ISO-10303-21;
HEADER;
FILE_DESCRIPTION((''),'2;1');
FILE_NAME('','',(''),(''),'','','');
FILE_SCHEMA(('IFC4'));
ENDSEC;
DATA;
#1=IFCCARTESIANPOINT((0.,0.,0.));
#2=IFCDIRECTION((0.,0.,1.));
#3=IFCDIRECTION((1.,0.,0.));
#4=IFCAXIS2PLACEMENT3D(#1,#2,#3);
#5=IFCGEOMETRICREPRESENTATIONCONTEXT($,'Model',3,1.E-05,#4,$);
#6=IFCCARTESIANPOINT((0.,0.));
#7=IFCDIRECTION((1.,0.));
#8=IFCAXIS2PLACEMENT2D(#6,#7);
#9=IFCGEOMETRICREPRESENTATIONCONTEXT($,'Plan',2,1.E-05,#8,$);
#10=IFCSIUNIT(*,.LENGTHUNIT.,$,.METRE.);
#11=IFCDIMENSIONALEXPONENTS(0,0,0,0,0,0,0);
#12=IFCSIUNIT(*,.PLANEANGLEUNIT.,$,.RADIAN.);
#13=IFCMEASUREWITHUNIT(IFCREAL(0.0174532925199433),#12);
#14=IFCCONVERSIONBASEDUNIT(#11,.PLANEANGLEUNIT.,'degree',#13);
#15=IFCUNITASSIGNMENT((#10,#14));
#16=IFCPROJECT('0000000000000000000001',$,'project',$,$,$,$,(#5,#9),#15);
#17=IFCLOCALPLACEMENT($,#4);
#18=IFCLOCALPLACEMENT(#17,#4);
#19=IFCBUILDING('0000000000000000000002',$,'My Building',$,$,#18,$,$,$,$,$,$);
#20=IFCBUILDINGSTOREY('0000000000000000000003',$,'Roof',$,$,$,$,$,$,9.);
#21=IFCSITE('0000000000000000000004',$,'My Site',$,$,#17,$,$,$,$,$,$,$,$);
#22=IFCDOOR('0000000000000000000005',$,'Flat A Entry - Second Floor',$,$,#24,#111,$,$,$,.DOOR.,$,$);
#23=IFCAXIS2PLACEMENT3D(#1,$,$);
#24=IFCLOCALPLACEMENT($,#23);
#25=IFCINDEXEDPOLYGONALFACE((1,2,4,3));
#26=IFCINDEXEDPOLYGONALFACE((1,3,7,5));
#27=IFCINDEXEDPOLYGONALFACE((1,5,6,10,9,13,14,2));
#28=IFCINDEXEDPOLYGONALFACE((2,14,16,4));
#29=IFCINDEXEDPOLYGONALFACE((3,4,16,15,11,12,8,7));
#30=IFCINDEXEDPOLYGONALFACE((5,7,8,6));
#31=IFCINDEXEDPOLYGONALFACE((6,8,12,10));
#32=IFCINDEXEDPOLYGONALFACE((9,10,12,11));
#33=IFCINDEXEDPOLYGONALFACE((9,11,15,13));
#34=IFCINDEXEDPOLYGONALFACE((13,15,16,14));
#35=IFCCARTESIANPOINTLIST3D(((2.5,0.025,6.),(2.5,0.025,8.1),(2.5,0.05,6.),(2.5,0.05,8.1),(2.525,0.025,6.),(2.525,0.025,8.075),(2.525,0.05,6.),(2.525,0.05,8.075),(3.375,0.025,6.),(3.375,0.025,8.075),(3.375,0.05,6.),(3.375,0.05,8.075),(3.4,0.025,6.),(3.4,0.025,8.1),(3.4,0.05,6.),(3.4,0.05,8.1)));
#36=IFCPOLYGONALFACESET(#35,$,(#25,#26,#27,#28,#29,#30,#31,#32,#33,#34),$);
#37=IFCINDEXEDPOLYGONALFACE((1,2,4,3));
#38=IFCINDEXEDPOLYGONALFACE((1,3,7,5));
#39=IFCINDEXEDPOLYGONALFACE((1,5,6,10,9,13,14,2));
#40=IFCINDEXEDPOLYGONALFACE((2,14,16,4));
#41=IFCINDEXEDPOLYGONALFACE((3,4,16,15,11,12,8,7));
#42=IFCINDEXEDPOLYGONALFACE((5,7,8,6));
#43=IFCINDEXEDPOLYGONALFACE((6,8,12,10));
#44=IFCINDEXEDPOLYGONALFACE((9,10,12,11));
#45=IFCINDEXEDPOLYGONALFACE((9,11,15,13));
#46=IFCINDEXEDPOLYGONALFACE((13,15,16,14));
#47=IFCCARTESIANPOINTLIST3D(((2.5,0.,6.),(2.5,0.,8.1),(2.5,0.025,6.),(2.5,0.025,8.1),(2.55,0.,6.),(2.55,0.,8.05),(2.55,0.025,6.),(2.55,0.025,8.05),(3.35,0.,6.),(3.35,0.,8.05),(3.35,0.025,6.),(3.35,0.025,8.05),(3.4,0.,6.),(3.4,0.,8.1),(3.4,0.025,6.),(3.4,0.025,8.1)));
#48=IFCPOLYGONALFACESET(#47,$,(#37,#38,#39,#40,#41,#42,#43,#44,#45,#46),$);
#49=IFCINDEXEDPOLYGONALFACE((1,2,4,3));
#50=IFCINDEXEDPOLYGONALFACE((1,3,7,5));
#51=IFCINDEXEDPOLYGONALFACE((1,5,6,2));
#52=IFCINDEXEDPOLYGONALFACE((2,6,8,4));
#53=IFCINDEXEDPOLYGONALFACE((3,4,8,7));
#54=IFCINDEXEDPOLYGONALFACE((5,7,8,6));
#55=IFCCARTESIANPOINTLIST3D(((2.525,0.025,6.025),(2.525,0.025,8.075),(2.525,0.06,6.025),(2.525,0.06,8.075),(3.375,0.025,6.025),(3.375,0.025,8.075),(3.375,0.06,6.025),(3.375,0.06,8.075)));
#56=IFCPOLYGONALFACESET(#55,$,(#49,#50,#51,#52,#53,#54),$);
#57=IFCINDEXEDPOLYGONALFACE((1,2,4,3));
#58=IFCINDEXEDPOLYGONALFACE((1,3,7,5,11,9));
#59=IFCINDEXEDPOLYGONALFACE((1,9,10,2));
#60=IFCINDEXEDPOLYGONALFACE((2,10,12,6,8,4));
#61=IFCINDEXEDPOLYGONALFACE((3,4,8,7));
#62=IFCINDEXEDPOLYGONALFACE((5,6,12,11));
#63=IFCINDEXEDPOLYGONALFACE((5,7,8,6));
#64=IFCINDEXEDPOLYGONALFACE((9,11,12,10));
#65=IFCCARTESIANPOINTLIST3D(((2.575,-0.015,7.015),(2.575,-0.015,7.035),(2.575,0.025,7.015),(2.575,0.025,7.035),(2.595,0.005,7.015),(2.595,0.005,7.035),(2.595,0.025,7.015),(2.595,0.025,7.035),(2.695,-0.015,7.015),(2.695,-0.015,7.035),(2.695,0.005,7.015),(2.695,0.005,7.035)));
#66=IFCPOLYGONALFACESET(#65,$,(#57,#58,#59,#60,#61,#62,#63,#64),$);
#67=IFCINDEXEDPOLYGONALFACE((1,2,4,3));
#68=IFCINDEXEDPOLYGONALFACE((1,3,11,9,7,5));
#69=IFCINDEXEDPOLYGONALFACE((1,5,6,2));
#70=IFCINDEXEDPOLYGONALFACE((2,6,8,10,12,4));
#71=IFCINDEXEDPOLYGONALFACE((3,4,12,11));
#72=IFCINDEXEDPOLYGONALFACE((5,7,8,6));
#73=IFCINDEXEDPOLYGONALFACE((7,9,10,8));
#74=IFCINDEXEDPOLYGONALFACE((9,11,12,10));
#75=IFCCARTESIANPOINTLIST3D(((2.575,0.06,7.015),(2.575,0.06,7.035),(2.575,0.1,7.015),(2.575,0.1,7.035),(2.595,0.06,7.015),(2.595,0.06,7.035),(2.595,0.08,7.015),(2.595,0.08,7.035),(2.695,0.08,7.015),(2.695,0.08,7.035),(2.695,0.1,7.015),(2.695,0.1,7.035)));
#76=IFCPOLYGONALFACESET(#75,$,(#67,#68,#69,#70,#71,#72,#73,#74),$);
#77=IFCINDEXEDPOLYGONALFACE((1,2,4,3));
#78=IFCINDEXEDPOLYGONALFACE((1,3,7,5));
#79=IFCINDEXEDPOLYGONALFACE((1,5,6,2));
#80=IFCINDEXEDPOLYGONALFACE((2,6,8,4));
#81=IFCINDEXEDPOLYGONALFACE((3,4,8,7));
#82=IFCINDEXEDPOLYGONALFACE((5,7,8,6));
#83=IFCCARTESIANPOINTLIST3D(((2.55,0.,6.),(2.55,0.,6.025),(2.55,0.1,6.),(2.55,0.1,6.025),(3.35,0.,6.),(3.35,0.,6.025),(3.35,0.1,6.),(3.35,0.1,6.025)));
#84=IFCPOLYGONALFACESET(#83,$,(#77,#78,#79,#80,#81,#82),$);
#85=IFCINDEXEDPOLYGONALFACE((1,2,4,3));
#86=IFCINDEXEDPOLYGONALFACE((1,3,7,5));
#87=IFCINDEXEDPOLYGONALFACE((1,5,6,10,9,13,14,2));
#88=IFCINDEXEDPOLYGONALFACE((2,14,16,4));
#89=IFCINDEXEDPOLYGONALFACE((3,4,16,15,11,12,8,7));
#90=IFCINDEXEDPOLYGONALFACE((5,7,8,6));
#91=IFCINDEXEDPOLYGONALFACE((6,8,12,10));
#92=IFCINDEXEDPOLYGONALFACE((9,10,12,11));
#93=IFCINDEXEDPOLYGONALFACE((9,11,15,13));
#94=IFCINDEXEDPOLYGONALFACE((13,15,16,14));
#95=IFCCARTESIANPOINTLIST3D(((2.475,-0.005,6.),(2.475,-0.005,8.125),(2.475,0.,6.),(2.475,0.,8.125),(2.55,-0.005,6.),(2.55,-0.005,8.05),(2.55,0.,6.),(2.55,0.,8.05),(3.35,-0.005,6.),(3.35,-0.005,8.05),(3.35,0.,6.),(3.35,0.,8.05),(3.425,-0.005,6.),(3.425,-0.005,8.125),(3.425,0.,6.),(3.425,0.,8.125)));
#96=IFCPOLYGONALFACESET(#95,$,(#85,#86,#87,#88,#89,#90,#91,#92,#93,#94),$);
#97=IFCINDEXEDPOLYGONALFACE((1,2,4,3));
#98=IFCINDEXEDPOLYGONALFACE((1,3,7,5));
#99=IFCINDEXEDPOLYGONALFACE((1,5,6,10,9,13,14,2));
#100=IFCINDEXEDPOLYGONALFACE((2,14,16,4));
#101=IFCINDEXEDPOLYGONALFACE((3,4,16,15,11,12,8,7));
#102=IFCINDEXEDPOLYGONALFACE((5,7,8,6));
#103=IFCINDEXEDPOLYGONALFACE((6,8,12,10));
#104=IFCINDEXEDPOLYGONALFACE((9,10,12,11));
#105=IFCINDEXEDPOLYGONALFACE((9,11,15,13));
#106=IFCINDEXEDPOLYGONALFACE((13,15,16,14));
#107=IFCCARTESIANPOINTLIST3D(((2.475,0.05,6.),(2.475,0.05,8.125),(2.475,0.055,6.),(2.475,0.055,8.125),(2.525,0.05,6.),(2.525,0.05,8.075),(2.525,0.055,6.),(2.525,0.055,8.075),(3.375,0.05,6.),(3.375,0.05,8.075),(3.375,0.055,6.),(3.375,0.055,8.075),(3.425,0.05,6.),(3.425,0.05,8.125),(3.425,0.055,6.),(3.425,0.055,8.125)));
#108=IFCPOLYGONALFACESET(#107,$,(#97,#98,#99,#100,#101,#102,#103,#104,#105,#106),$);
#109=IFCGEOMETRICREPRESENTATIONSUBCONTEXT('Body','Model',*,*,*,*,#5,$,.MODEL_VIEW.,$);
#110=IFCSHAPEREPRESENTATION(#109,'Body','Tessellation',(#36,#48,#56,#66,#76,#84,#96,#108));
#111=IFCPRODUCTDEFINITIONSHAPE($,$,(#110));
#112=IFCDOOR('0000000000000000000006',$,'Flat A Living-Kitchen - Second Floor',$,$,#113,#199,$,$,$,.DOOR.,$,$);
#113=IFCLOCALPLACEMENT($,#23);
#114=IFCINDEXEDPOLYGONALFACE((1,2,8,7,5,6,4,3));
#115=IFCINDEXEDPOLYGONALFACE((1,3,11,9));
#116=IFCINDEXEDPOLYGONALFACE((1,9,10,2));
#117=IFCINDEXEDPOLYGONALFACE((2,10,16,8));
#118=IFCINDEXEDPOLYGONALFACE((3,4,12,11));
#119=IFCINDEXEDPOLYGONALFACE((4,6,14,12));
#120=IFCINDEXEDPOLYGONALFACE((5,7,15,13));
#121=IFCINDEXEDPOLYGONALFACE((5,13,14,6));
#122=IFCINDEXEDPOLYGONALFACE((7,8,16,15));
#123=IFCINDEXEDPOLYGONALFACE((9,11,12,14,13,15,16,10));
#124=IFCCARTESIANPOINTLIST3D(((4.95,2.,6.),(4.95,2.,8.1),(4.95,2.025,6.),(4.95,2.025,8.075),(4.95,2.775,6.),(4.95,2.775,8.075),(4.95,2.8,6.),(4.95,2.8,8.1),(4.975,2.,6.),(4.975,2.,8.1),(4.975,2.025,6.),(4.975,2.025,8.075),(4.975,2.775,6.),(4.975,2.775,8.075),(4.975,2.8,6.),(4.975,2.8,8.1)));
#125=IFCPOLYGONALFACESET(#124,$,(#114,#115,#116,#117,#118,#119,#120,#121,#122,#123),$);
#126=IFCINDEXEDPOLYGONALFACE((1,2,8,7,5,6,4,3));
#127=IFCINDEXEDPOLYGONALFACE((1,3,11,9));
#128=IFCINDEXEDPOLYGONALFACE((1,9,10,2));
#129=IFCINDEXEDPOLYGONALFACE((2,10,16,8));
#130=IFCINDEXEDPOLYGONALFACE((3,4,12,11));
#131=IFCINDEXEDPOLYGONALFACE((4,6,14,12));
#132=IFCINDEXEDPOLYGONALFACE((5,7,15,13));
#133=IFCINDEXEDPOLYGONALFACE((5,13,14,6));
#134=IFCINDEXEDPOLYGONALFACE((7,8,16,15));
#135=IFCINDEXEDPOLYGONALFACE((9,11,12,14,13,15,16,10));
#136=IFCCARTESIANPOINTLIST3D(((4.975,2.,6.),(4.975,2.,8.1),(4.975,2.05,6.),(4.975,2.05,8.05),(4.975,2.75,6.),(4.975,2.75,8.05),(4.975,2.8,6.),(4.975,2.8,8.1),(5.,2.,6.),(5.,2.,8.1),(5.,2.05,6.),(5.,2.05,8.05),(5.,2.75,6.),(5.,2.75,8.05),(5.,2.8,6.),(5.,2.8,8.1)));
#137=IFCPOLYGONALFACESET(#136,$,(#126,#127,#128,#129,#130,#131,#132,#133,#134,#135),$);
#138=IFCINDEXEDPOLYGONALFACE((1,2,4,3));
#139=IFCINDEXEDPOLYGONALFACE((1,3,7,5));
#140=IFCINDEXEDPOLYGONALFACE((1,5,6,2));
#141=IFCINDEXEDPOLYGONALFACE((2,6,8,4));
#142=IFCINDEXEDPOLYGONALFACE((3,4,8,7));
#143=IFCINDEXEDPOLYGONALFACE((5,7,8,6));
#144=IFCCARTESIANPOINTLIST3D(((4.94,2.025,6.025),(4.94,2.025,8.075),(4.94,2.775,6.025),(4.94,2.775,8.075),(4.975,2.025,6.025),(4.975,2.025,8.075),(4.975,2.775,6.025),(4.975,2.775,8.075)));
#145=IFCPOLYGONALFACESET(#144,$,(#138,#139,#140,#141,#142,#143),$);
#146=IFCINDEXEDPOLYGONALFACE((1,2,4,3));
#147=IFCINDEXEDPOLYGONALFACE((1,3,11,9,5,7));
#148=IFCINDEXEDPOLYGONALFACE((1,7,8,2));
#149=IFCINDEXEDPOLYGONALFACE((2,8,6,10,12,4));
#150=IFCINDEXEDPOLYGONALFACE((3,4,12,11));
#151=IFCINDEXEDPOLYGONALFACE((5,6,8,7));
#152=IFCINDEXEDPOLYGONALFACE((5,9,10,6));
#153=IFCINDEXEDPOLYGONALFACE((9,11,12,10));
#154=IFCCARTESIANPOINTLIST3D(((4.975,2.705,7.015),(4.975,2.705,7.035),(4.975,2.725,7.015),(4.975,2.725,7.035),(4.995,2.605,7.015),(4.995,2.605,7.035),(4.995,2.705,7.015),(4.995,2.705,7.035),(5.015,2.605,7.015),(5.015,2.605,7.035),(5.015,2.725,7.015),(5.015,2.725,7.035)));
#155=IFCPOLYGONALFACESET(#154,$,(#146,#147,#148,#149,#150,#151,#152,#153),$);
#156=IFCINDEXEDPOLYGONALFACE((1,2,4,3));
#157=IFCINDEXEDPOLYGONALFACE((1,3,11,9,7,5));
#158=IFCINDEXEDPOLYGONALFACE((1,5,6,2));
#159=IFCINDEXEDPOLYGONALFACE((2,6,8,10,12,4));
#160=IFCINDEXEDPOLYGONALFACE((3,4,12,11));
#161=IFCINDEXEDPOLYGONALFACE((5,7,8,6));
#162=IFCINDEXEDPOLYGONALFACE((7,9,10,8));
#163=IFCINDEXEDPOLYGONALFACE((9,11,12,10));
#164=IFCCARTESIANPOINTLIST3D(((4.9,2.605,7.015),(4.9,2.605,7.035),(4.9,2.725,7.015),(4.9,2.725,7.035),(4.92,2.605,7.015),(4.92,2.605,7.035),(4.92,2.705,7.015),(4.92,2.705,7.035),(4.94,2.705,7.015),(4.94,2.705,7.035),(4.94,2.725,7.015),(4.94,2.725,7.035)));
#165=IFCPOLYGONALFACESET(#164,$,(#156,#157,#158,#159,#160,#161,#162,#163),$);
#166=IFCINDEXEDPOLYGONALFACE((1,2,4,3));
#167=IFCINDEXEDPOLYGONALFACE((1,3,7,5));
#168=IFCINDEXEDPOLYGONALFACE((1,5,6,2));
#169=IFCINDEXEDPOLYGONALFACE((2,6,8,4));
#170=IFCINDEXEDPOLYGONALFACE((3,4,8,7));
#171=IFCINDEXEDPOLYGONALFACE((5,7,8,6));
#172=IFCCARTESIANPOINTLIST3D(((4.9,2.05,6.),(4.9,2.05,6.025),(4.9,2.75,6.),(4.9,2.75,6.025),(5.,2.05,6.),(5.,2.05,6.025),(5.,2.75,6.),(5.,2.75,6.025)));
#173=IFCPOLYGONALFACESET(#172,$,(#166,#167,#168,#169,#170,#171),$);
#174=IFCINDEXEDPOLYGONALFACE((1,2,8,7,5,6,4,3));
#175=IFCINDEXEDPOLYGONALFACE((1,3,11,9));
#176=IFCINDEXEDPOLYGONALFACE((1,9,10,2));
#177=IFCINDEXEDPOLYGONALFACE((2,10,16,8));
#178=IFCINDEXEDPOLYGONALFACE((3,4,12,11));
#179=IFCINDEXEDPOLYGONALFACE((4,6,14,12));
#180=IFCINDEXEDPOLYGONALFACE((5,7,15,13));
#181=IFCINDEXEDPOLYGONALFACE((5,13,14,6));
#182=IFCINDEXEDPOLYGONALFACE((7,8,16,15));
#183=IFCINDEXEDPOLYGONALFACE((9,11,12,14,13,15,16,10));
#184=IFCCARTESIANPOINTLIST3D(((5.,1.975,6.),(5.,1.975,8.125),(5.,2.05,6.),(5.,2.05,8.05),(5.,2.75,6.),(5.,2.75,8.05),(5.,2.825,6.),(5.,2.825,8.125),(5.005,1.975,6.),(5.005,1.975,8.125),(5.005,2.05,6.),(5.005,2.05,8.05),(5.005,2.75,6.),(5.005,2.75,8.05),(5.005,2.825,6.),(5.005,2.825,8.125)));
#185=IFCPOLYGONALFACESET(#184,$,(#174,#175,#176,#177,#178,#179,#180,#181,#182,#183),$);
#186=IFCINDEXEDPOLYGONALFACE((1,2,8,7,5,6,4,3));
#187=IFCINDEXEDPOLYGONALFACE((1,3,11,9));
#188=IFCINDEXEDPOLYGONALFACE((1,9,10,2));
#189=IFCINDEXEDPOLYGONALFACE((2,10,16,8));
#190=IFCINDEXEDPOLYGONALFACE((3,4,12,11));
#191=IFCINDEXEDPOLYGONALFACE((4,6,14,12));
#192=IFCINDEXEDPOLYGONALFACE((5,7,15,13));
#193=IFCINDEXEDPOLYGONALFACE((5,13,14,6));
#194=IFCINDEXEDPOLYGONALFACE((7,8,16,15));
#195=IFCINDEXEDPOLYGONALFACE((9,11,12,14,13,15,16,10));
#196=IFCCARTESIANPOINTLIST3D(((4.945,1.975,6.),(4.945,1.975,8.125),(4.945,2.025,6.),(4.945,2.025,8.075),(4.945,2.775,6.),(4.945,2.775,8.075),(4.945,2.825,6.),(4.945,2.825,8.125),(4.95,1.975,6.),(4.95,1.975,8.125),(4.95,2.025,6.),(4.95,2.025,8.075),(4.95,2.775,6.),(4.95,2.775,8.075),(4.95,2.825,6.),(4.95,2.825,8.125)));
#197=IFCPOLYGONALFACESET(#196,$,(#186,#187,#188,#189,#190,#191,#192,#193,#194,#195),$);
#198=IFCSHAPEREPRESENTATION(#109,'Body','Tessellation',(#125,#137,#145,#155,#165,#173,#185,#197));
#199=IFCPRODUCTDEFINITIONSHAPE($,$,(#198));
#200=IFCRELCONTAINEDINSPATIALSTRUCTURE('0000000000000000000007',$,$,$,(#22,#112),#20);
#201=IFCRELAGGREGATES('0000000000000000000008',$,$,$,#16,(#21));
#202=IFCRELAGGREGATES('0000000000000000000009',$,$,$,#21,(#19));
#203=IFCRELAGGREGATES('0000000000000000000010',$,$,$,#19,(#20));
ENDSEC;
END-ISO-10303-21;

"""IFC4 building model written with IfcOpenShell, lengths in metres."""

from ifc_helpers import new_model, entity, si_unit, converted_unit, frame, origin_with_axes, origin_2d_with_axis, place, context, subcontext, project, spatial, line, indexed_curve, outline, extrude, element, save


model = new_model("IFC4")

# Units and contexts
model_context = context("Model", 3, precision=1e-05, world=origin_with_axes())
plan_context = context("Plan", 2, precision=1e-05, world=origin_2d_with_axis())
body_context = subcontext(model_context, "Body", "Model", "MODEL_VIEW")
ifc_project = project(units=[si_unit("LENGTHUNIT", "METRE"), converted_unit("PLANEANGLEUNIT", "degree", entity("IfcReal", 0.0174532925199433), si_unit("PLANEANGLEUNIT", "RADIAN"), dimensions=[0, 0, 0, 0, 0, 0, 0])], contexts=[model_context, plan_context])

# Site, building, storey
site_placement = place(None, origin_with_axes())
site = spatial("IfcSite", under=ifc_project, at=site_placement, Name="My Site")
building_placement = place(site_placement, origin_with_axes())
building = spatial("IfcBuilding", under=site, at=building_placement, Name="My Building")
storey = spatial("IfcBuildingStorey", under=building, Name="Roof", Elevation=9.0)

# Doors
door_1_placement = place(None, frame((2.5, 0.0, 6.0), z_axis=(0.0, 0.0, 1.0), x_axis=(1.0, 0.0, 0.0)))
element("IfcDoor", 1, at=door_1_placement, inside=storey, Name="Flat A Entry - Second Floor", PredefinedType="DOOR", context=body_context, shape_type="SweptSolid", body=[
    extrude(outline(indexed_curve([(0.0, 0.0), (0.0, 2.1), (0.9, 2.1), (0.9, 0.0), (0.875, 0.0), (0.875, 2.075), (0.025, 2.075), (0.025, 0.0)], segments=[line(1, 2, 3, 4, 5, 6, 7, 8, 1)])), frame((0.0, 0.025, 0.0), z_axis=(0.0, -1.0, 0.0), x_axis=(1.0, 0.0, 0.0)), (0.0, 0.0, -1.0), 0.025),
    extrude(outline(indexed_curve([(0.0, 0.0), (0.0, 2.1), (0.9, 2.1), (0.9, 0.0), (0.85, 0.0), (0.85, 2.05), (0.05, 2.05), (0.05, 0.0)], segments=[line(1, 2, 3, 4, 5, 6, 7, 8, 1)])), frame((0.0, 0.0, 0.0), z_axis=(0.0, -1.0, 0.0), x_axis=(1.0, 0.0, 0.0)), (0.0, 0.0, -1.0), 0.025),
    extrude(outline(indexed_curve([(0.0, 0.0), (0.85, 0.0), (0.85, 0.035), (0.0, 0.035)], segments=[line(1, 2, 3, 4, 1)])), frame((0.025, 0.025, 0.025), z_axis=(0.0, 0.0, 1.0), x_axis=(1.0, 0.0, 0.0)), (0.0, 0.0, 1.0), 2.05),
    extrude(outline(indexed_curve([(0.0, 0.0), (0.0, -0.04), (0.12, -0.04), (0.12, -0.02), (0.02, -0.02), (0.02, 0.0)], segments=[line(1, 2, 3, 4, 5, 6, 1)])), frame((0.075, 0.025, 1.015), z_axis=(0.0, 0.0, 1.0), x_axis=(1.0, 0.0, 0.0)), (0.0, 0.0, 1.0), 0.02),
    extrude(outline(indexed_curve([(0.0, 0.0), (0.0, 0.04), (0.12, 0.04), (0.12, 0.02), (0.02, 0.02), (0.02, 0.0)], segments=[line(1, 2, 3, 4, 5, 6, 1)])), frame((0.075, 0.06, 1.015), z_axis=(0.0, 0.0, 1.0), x_axis=(1.0, 0.0, 0.0)), (0.0, 0.0, 1.0), 0.02),
    extrude(outline(indexed_curve([(0.0, 0.0), (0.8, 0.0), (0.8, 0.1), (0.0, 0.1)], segments=[line(1, 2, 3, 4, 1)])), frame((0.05, 0.0, 0.0), z_axis=(0.0, 0.0, 1.0), x_axis=(1.0, 0.0, 0.0)), (0.0, 0.0, 1.0), 0.025),
    extrude(outline(indexed_curve([(0.0, 0.0), (0.0, 2.125), (0.95, 2.125), (0.95, 0.0), (0.875, 0.0), (0.875, 2.05), (0.075, 2.05), (0.075, 0.0)], segments=[line(1, 2, 3, 4, 5, 6, 7, 8, 1)])), frame((-0.025, -0.005, 0.0), z_axis=(0.0, -1.0, 0.0), x_axis=(1.0, 0.0, 0.0)), (0.0, 0.0, -1.0), 0.005),
    extrude(outline(indexed_curve([(0.0, 0.0), (0.0, 2.125), (0.95, 2.125), (0.95, 0.0), (0.9, 0.0), (0.9, 2.075), (0.05, 2.075), (0.05, 0.0)], segments=[line(1, 2, 3, 4, 5, 6, 7, 8, 1)])), frame((-0.025, 0.05, 0.0), z_axis=(0.0, -1.0, 0.0), x_axis=(1.0, 0.0, 0.0)), (0.0, 0.0, -1.0), 0.005),
])
door_2_placement = place(None, frame((5.0, 2.0, 6.0), z_axis=(0.0, 0.0, 1.0), x_axis=(0.0, 1.0, 0.0)))
element("IfcDoor", 2, at=door_2_placement, inside=storey, Name="Flat A Living-Kitchen - Second Floor", PredefinedType="DOOR", context=body_context, shape_type="SweptSolid", body=[
    extrude(outline(indexed_curve([(0.0, 0.0), (0.0, 2.1), (0.8, 2.1), (0.8, 0.0), (0.775, 0.0), (0.775, 2.075), (0.025, 2.075), (0.025, 0.0)], segments=[line(1, 2, 3, 4, 5, 6, 7, 8, 1)])), frame((0.0, 0.025, 0.0), z_axis=(0.0, -1.0, 0.0), x_axis=(1.0, 0.0, 0.0)), (0.0, 0.0, -1.0), 0.025),
    extrude(outline(indexed_curve([(0.0, 0.0), (0.0, 2.1), (0.8, 2.1), (0.8, 0.0), (0.75, 0.0), (0.75, 2.05), (0.05, 2.05), (0.05, 0.0)], segments=[line(1, 2, 3, 4, 5, 6, 7, 8, 1)])), frame((0.0, 0.0, 0.0), z_axis=(0.0, -1.0, 0.0), x_axis=(1.0, 0.0, 0.0)), (0.0, 0.0, -1.0), 0.025),
    extrude(outline(indexed_curve([(0.0, 0.0), (0.75, 0.0), (0.75, 0.035), (0.0, 0.035)], segments=[line(1, 2, 3, 4, 1)])), frame((0.025, 0.025, 0.025), z_axis=(0.0, 0.0, 1.0), x_axis=(1.0, 0.0, 0.0)), (0.0, 0.0, 1.0), 2.05),
    extrude(outline(indexed_curve([(0.0, 0.0), (0.0, -0.04), (-0.12, -0.04), (-0.12, -0.02), (-0.02, -0.02), (-0.02, 0.0)], segments=[line(1, 2, 3, 4, 5, 6, 1)])), frame((0.725, 0.025, 1.015), z_axis=(0.0, 0.0, 1.0), x_axis=(1.0, 0.0, 0.0)), (0.0, 0.0, 1.0), 0.02),
    extrude(outline(indexed_curve([(0.0, 0.0), (0.0, 0.04), (-0.12, 0.04), (-0.12, 0.02), (-0.02, 0.02), (-0.02, 0.0)], segments=[line(1, 2, 3, 4, 5, 6, 1)])), frame((0.725, 0.06, 1.015), z_axis=(0.0, 0.0, 1.0), x_axis=(1.0, 0.0, 0.0)), (0.0, 0.0, 1.0), 0.02),
    extrude(outline(indexed_curve([(0.0, 0.0), (0.7, 0.0), (0.7, 0.1), (0.0, 0.1)], segments=[line(1, 2, 3, 4, 1)])), frame((0.05, 0.0, 0.0), z_axis=(0.0, 0.0, 1.0), x_axis=(1.0, 0.0, 0.0)), (0.0, 0.0, 1.0), 0.025),
    extrude(outline(indexed_curve([(0.0, 0.0), (0.0, 2.125), (0.85, 2.125), (0.85, 0.0), (0.775, 0.0), (0.775, 2.05), (0.075, 2.05), (0.075, 0.0)], segments=[line(1, 2, 3, 4, 5, 6, 7, 8, 1)])), frame((-0.025, -0.005, 0.0), z_axis=(0.0, -1.0, 0.0), x_axis=(1.0, 0.0, 0.0)), (0.0, 0.0, -1.0), 0.005),
    extrude(outline(indexed_curve([(0.0, 0.0), (0.0, 2.125), (0.85, 2.125), (0.85, 0.0), (0.8, 0.0), (0.8, 2.075), (0.05, 2.075), (0.05, 0.0)], segments=[line(1, 2, 3, 4, 5, 6, 7, 8, 1)])), frame((-0.025, 0.05, 0.0), z_axis=(0.0, -1.0, 0.0), x_axis=(1.0, 0.0, 0.0)), (0.0, 0.0, -1.0), 0.005),
])

save(model, "model.ifc")
